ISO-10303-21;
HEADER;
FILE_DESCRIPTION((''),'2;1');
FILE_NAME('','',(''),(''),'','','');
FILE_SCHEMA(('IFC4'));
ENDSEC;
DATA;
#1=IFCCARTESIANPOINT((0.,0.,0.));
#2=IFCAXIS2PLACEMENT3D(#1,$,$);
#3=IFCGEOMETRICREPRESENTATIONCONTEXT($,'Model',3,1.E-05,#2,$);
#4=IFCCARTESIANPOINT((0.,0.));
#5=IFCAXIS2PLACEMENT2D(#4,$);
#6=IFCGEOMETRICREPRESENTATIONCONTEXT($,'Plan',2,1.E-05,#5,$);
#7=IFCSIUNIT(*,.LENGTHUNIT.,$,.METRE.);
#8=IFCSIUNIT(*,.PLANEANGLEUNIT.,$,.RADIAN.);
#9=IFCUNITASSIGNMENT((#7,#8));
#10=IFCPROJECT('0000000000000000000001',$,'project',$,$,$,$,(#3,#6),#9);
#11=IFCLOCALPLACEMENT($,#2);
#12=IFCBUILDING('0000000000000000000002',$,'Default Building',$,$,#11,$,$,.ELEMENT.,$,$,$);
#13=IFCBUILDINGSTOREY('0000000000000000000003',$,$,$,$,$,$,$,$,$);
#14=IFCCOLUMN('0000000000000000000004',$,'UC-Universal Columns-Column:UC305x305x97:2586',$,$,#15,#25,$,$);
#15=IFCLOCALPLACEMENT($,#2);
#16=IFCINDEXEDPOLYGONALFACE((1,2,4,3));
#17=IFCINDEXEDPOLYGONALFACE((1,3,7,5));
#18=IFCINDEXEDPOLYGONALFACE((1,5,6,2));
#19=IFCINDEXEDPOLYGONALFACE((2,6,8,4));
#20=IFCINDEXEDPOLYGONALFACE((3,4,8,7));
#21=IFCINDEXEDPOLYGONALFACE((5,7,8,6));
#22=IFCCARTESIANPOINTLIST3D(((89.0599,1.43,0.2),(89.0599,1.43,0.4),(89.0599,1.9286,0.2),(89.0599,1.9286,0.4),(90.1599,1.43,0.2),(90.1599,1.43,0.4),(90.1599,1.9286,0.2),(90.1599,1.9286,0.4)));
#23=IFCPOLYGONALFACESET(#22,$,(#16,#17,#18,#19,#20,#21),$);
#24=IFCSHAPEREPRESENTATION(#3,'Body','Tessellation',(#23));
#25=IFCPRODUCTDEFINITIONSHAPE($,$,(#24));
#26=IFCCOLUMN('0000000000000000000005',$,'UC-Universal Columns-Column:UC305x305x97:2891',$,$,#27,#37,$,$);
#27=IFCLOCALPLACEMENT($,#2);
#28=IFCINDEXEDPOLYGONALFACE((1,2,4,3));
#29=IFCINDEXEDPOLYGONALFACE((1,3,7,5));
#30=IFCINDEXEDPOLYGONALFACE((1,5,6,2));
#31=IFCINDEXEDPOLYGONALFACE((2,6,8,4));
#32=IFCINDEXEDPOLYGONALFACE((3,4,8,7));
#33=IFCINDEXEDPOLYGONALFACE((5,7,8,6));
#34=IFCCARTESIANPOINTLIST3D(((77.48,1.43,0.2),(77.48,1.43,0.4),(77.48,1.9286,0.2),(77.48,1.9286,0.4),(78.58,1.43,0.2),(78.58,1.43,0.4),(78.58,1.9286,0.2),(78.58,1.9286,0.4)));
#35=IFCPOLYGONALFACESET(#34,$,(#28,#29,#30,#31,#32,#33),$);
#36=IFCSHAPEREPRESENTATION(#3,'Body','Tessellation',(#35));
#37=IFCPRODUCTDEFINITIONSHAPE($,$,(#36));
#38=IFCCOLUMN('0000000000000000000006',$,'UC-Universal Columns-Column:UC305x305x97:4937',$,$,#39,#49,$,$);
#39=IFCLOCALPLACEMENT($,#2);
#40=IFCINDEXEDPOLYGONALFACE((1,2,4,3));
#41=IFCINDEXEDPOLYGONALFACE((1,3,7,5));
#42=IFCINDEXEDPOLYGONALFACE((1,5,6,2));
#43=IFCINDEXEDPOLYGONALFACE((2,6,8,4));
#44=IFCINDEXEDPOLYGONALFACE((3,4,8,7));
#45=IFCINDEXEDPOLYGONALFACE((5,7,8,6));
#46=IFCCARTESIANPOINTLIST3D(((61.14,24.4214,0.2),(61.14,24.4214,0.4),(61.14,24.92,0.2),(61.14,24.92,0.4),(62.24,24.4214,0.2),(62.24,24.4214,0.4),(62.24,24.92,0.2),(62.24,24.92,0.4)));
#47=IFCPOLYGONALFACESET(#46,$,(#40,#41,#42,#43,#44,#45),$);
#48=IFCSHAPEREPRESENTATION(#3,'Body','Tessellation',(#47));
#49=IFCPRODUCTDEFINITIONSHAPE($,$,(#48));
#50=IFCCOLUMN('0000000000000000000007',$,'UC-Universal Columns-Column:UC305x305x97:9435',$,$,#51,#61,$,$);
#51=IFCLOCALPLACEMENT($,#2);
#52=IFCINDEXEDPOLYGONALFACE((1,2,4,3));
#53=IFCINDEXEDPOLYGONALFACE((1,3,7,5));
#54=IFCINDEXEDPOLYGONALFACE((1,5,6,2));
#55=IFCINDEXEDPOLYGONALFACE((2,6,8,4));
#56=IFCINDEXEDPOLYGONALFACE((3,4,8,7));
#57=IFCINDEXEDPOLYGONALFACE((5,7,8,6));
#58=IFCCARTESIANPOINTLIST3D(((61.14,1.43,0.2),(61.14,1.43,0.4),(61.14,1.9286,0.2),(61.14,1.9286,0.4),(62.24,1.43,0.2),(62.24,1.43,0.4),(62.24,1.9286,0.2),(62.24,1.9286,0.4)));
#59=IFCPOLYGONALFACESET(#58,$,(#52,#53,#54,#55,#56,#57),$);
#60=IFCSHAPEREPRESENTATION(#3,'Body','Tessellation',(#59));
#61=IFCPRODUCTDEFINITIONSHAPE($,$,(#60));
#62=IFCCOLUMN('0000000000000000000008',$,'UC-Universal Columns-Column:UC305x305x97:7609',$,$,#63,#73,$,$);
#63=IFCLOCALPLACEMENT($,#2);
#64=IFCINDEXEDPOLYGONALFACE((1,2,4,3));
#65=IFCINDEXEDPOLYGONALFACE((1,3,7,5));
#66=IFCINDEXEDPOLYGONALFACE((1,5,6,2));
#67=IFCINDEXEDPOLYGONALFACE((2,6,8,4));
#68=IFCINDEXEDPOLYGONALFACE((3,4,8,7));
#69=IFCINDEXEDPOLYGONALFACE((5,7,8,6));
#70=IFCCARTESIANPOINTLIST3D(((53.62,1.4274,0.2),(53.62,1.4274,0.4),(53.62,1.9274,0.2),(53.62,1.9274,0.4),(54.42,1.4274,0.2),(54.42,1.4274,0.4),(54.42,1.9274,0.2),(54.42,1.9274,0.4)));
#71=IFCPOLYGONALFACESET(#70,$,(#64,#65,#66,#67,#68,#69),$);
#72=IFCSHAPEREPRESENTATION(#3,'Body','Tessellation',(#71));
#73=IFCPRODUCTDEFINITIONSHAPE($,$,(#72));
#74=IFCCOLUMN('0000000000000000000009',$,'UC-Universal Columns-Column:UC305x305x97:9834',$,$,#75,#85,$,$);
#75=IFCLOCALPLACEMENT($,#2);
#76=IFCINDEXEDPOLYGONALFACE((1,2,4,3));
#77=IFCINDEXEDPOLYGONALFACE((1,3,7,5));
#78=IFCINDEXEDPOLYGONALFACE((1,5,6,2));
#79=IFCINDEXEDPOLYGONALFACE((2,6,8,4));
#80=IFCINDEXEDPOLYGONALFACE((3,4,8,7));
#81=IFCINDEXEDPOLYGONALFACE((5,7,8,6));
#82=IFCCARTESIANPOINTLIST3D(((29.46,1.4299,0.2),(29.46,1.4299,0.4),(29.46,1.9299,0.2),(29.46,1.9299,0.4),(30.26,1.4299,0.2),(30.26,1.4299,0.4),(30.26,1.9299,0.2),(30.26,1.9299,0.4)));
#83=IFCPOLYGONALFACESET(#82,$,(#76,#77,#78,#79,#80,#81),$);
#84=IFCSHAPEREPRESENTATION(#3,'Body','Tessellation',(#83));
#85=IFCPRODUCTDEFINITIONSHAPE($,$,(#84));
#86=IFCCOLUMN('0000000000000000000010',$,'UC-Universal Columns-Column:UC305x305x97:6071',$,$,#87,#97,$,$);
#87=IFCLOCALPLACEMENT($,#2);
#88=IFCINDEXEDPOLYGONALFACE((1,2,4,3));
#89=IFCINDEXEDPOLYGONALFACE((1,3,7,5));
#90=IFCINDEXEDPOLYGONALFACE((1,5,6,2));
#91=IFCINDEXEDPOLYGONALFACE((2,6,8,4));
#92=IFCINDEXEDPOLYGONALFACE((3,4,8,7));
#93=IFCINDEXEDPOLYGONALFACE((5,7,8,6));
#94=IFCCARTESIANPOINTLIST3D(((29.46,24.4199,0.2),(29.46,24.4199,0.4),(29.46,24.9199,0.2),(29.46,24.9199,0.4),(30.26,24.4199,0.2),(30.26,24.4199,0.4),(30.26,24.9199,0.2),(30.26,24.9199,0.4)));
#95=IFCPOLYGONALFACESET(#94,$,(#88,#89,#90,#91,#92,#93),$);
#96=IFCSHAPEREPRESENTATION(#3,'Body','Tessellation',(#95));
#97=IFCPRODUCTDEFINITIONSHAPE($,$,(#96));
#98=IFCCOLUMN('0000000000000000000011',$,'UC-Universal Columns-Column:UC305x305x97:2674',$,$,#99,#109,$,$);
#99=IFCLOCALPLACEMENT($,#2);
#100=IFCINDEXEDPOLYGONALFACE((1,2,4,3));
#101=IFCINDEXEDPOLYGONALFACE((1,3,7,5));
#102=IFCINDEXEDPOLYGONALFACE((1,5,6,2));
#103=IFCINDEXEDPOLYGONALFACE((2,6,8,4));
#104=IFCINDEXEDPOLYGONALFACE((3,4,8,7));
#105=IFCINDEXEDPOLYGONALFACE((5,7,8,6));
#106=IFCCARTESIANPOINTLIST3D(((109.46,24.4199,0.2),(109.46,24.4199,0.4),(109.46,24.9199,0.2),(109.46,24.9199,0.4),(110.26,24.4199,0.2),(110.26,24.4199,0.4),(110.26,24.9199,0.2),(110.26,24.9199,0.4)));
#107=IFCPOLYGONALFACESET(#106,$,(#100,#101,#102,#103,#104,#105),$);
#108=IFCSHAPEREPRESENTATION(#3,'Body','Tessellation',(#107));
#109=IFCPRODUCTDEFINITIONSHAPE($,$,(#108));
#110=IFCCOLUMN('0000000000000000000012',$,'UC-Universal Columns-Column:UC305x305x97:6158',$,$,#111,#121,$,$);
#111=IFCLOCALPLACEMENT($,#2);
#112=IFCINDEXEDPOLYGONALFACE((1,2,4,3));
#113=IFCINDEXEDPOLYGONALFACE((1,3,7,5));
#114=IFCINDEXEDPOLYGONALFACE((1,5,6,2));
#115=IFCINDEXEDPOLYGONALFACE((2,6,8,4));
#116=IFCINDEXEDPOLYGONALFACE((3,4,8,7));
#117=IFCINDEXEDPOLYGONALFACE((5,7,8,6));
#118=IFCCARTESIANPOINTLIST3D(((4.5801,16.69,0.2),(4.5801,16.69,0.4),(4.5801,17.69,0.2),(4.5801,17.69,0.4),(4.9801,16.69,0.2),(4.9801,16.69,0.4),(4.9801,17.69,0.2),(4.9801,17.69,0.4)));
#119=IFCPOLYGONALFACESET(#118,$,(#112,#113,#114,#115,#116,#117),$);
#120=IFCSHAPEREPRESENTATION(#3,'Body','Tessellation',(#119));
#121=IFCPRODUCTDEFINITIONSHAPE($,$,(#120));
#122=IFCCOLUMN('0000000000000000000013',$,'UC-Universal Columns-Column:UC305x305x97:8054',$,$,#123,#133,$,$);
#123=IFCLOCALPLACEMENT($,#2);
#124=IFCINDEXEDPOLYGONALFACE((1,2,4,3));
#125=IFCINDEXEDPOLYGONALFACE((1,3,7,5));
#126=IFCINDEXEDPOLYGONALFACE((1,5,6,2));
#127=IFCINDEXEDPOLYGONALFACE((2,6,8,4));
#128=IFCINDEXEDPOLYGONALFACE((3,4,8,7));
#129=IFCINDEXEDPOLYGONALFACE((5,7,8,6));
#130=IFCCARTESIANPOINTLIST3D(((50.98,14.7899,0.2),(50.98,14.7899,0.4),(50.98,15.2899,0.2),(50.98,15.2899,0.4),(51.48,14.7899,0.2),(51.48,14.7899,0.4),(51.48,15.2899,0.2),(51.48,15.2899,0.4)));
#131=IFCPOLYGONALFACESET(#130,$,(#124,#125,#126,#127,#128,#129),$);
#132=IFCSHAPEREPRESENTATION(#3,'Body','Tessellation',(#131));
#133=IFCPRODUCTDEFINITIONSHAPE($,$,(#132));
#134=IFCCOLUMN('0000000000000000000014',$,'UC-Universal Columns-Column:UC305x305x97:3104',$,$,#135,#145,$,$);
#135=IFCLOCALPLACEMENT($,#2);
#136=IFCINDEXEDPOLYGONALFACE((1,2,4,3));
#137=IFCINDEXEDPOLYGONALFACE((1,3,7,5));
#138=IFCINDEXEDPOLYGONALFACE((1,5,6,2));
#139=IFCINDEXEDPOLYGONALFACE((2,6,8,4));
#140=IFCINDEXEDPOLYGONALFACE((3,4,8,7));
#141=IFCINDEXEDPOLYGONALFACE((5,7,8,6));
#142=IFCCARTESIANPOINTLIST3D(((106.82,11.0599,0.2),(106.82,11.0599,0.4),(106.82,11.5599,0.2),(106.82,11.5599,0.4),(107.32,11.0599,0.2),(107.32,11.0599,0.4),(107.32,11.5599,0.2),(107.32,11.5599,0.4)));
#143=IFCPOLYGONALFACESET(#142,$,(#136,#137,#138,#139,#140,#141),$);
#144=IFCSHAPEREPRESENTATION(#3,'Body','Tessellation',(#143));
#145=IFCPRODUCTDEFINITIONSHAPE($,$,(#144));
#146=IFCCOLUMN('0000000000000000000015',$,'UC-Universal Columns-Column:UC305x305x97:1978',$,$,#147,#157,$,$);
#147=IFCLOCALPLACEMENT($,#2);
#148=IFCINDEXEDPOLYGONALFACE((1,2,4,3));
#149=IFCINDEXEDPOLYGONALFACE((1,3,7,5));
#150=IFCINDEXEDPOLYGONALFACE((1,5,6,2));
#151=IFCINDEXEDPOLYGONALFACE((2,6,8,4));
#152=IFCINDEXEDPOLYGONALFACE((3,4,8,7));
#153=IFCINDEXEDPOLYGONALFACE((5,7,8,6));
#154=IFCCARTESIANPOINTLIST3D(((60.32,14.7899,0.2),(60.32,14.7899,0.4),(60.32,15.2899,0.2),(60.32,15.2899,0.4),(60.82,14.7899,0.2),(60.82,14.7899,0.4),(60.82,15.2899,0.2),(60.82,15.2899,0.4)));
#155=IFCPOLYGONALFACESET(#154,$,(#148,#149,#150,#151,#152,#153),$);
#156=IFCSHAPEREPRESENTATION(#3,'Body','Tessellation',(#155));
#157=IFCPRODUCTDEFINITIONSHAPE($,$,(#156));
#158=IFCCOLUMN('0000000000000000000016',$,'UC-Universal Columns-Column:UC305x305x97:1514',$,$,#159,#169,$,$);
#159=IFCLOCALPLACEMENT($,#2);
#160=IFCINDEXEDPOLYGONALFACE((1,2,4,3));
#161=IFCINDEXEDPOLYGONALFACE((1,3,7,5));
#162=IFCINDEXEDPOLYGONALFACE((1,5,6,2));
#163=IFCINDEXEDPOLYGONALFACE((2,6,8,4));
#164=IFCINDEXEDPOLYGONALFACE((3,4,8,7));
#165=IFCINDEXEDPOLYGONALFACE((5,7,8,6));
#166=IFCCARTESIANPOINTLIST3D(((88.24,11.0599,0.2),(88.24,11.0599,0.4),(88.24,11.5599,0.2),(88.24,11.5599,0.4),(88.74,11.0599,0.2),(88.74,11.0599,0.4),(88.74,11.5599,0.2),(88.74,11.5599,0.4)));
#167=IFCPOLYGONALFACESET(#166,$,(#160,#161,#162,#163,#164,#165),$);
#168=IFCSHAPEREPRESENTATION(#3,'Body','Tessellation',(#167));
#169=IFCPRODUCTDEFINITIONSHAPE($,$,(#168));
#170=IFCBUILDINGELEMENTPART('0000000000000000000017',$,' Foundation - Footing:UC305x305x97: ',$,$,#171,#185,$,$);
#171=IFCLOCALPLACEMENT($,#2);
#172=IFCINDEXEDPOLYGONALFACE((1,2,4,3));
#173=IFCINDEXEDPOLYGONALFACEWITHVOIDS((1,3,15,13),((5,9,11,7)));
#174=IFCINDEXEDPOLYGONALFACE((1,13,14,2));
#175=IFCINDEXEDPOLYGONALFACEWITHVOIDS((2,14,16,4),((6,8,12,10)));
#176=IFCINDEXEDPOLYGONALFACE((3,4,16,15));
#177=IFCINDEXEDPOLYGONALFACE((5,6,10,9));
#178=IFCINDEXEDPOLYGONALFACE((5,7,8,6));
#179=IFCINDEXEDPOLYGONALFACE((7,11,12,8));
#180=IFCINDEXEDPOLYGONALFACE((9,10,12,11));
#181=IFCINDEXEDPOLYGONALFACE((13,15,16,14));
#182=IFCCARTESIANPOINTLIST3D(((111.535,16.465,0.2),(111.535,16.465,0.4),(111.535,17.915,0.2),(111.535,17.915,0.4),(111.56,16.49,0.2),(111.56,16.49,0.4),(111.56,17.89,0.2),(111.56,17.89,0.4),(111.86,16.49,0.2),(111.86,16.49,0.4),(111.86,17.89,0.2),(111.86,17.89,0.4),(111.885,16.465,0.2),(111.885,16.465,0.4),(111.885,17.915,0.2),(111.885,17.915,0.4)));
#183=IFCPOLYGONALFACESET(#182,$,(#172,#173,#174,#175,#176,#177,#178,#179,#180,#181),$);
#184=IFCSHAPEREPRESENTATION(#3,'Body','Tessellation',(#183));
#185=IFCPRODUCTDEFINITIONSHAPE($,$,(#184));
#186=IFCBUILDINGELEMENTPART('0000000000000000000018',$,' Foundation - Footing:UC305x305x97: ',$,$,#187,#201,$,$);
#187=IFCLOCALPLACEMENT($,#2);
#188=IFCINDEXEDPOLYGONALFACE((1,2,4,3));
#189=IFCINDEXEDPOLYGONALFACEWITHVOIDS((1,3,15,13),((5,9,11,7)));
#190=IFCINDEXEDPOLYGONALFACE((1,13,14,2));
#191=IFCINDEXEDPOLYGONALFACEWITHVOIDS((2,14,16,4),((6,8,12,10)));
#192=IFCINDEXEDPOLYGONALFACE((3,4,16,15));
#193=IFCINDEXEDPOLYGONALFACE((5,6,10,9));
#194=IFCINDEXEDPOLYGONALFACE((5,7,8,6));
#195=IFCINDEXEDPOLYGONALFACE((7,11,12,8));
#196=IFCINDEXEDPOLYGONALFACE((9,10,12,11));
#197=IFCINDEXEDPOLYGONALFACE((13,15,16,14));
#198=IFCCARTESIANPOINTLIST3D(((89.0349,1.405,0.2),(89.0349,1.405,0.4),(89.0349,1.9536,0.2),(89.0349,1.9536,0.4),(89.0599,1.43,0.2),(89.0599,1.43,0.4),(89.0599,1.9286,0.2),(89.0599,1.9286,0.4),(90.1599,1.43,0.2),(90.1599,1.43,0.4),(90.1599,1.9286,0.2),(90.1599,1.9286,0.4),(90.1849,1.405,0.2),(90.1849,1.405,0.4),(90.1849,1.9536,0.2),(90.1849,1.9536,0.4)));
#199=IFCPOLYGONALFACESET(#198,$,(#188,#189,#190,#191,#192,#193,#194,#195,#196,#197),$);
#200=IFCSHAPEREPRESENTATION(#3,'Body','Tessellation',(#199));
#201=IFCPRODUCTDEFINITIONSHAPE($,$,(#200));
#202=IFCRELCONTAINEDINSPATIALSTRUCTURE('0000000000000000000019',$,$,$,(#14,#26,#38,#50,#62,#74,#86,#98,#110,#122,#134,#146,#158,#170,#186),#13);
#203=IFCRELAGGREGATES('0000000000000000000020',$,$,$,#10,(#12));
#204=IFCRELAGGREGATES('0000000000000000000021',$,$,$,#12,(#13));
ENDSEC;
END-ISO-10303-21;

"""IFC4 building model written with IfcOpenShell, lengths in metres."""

from ifc_helpers import new_model, si_unit, origin, origin_2d, place, context, project, spatial, polyline, outline, extrude, element, save


model = new_model("IFC4")

# Units and contexts
model_context = context("Model", 3, precision=1e-05, world=origin())
plan_context = context("Plan", 2, precision=1e-05, world=origin_2d())
ifc_project = project(units=[si_unit("LENGTHUNIT", "METRE"), si_unit("PLANEANGLEUNIT", "RADIAN")], contexts=[model_context, plan_context])

# Building, storey
building_placement = place(None, origin())
building = spatial("IfcBuilding", under=ifc_project, at=building_placement, Name="Default Building", CompositionType="ELEMENT")
storey = spatial("IfcBuildingStorey", under=building)

# Columns
element("IfcColumn", 1, inside=storey, Name="UC-Universal Columns-Column:UC305x305x97:2586", context=model_context, shape_type="SweptSolid", body=[
    extrude(outline(polyline([(90.1599, 1.43, 0.2), (89.0599, 1.43, 0.2), (89.0599, 1.9286, 0.2), (90.1599, 1.9286, 0.2), (90.1599, 1.43, 0.2)])), None, (0.0, 0.0, 1.0), 0.2),
])
element("IfcColumn", 2, inside=storey, Name="UC-Universal Columns-Column:UC305x305x97:2891", context=model_context, shape_type="SweptSolid", body=[
    extrude(outline(polyline([(77.48, 1.43, 0.2), (78.58, 1.43, 0.2), (78.58, 1.9286, 0.2), (77.48, 1.9286, 0.2), (77.48, 1.43, 0.2)])), None, (0.0, 0.0, 1.0), 0.2),
])
element("IfcColumn", 3, inside=storey, Name="UC-Universal Columns-Column:UC305x305x97:4937", context=model_context, shape_type="SweptSolid", body=[
    extrude(outline(polyline([(61.14, 24.4214, 0.2), (62.24, 24.4214, 0.2), (62.24, 24.92, 0.2), (61.14, 24.92, 0.2), (61.14, 24.4214, 0.2)])), None, (0.0, 0.0, 1.0), 0.2),
])
element("IfcColumn", 4, inside=storey, Name="UC-Universal Columns-Column:UC305x305x97:9435", context=model_context, shape_type="SweptSolid", body=[
    extrude(outline(polyline([(61.14, 1.43, 0.2), (62.24, 1.43, 0.2), (62.24, 1.9286, 0.2), (61.14, 1.9286, 0.2), (61.14, 1.43, 0.2)])), None, (0.0, 0.0, 1.0), 0.2),
])
element("IfcColumn", 5, inside=storey, Name="UC-Universal Columns-Column:UC305x305x97:7609", context=model_context, shape_type="SweptSolid", body=[
    extrude(outline(polyline([(54.42, 1.4274, 0.2), (53.62, 1.4274, 0.2), (53.62, 1.9274, 0.2), (54.42, 1.9274, 0.2), (54.42, 1.4274, 0.2)])), None, (0.0, 0.0, 1.0), 0.2),
])
element("IfcColumn", 6, inside=storey, Name="UC-Universal Columns-Column:UC305x305x97:9834", context=model_context, shape_type="SweptSolid", body=[
    extrude(outline(polyline([(30.26, 1.4299, 0.2), (29.46, 1.4299, 0.2), (29.46, 1.9299, 0.2), (30.26, 1.9299, 0.2), (30.26, 1.4299, 0.2)])), None, (0.0, 0.0, 1.0), 0.2),
])
element("IfcColumn", 7, inside=storey, Name="UC-Universal Columns-Column:UC305x305x97:6071", context=model_context, shape_type="SweptSolid", body=[
    extrude(outline(polyline([(30.26, 24.4199, 0.2), (29.46, 24.4199, 0.2), (29.46, 24.9199, 0.2), (30.26, 24.9199, 0.2), (30.26, 24.4199, 0.2)])), None, (0.0, 0.0, 1.0), 0.2),
])
element("IfcColumn", 8, inside=storey, Name="UC-Universal Columns-Column:UC305x305x97:2674", context=model_context, shape_type="SweptSolid", body=[
    extrude(outline(polyline([(110.26, 24.4199, 0.2), (109.46, 24.4199, 0.2), (109.46, 24.9199, 0.2), (110.26, 24.9199, 0.2), (110.26, 24.4199, 0.2)])), None, (0.0, 0.0, 1.0), 0.2),
])
element("IfcColumn", 9, inside=storey, Name="UC-Universal Columns-Column:UC305x305x97:6158", context=model_context, shape_type="SweptSolid", body=[
    extrude(outline(polyline([(4.5801, 17.69, 0.2), (4.9801, 17.69, 0.2), (4.9801, 16.69, 0.2), (4.5801, 16.69, 0.2), (4.5801, 17.69, 0.2)])), None, (0.0, 0.0, 1.0), 0.2),
])
element("IfcColumn", 10, inside=storey, Name="UC-Universal Columns-Column:UC305x305x97:8054", context=model_context, shape_type="SweptSolid", body=[
    extrude(outline(polyline([(50.98, 15.2899, 0.2), (51.48, 15.2899, 0.2), (51.48, 14.7899, 0.2), (50.98, 14.7899, 0.2), (50.98, 15.2899, 0.2)])), None, (0.0, 0.0, 1.0), 0.2),
])
element("IfcColumn", 11, inside=storey, Name="UC-Universal Columns-Column:UC305x305x97:3104", context=model_context, shape_type="SweptSolid", body=[
    extrude(outline(polyline([(106.82, 11.0599, 0.2), (107.32, 11.0599, 0.2), (107.32, 11.5599, 0.2), (106.82, 11.5599, 0.2), (106.82, 11.0599, 0.2)])), None, (0.0, 0.0, 1.0), 0.2),
])
element("IfcColumn", 12, inside=storey, Name="UC-Universal Columns-Column:UC305x305x97:1978", context=model_context, shape_type="SweptSolid", body=[
    extrude(outline(polyline([(60.82, 15.2899, 0.2), (60.32, 15.2899, 0.2), (60.32, 14.7899, 0.2), (60.82, 14.7899, 0.2), (60.82, 15.2899, 0.2)])), None, (0.0, 0.0, 1.0), 0.2),
])
element("IfcColumn", 13, inside=storey, Name="UC-Universal Columns-Column:UC305x305x97:1514", context=model_context, shape_type="SweptSolid", body=[
    extrude(outline(polyline([(88.74, 11.0599, 0.2), (88.24, 11.0599, 0.2), (88.24, 11.5599, 0.2), (88.74, 11.5599, 0.2), (88.74, 11.0599, 0.2)])), None, (0.0, 0.0, 1.0), 0.2),
])

# Building element parts, openings
building_element_part_1 = element("IfcBuildingElementPart", 14, inside=storey, Name=" Foundation - Footing:UC305x305x97: ", context=model_context, shape_type="SweptSolid", body=[
    extrude(outline(polyline([(111.885, 17.915, 0.2), (111.535, 17.915, 0.2), (111.535, 16.465, 0.2), (111.885, 16.465, 0.2), (111.885, 17.915, 0.2)])), None, (0.0, 0.0, 1.0), 0.2),
])
element("IfcOpeningElement", 15, inside=storey, cuts=building_element_part_1, context=model_context, shape_type="SweptSolid", body=[
    extrude(outline(polyline([(111.86, 17.89, 0.2), (111.56, 17.89, 0.2), (111.56, 16.49, 0.2), (111.86, 16.49, 0.2), (111.86, 17.89, 0.2)])), None, (0.0, 0.0, 1.0), 0.2),
])
building_element_part_2 = element("IfcBuildingElementPart", 16, inside=storey, Name=" Foundation - Footing:UC305x305x97: ", context=model_context, shape_type="SweptSolid", body=[
    extrude(outline(polyline([(90.1849, 1.405, 0.2), (89.0349, 1.405, 0.2), (89.0349, 1.9536, 0.2), (90.1849, 1.9536, 0.2), (90.1849, 1.405, 0.2)])), None, (0.0, 0.0, 1.0), 0.2),
])
element("IfcOpeningElement", 17, inside=storey, cuts=building_element_part_2, context=model_context, shape_type="SweptSolid", body=[
    extrude(outline(polyline([(90.1599, 1.43, 0.2), (89.0599, 1.43, 0.2), (89.0599, 1.9286, 0.2), (90.1599, 1.9286, 0.2), (90.1599, 1.43, 0.2)])), None, (0.0, 0.0, 1.0), 0.2),
])

save(model, "model.ifc")
